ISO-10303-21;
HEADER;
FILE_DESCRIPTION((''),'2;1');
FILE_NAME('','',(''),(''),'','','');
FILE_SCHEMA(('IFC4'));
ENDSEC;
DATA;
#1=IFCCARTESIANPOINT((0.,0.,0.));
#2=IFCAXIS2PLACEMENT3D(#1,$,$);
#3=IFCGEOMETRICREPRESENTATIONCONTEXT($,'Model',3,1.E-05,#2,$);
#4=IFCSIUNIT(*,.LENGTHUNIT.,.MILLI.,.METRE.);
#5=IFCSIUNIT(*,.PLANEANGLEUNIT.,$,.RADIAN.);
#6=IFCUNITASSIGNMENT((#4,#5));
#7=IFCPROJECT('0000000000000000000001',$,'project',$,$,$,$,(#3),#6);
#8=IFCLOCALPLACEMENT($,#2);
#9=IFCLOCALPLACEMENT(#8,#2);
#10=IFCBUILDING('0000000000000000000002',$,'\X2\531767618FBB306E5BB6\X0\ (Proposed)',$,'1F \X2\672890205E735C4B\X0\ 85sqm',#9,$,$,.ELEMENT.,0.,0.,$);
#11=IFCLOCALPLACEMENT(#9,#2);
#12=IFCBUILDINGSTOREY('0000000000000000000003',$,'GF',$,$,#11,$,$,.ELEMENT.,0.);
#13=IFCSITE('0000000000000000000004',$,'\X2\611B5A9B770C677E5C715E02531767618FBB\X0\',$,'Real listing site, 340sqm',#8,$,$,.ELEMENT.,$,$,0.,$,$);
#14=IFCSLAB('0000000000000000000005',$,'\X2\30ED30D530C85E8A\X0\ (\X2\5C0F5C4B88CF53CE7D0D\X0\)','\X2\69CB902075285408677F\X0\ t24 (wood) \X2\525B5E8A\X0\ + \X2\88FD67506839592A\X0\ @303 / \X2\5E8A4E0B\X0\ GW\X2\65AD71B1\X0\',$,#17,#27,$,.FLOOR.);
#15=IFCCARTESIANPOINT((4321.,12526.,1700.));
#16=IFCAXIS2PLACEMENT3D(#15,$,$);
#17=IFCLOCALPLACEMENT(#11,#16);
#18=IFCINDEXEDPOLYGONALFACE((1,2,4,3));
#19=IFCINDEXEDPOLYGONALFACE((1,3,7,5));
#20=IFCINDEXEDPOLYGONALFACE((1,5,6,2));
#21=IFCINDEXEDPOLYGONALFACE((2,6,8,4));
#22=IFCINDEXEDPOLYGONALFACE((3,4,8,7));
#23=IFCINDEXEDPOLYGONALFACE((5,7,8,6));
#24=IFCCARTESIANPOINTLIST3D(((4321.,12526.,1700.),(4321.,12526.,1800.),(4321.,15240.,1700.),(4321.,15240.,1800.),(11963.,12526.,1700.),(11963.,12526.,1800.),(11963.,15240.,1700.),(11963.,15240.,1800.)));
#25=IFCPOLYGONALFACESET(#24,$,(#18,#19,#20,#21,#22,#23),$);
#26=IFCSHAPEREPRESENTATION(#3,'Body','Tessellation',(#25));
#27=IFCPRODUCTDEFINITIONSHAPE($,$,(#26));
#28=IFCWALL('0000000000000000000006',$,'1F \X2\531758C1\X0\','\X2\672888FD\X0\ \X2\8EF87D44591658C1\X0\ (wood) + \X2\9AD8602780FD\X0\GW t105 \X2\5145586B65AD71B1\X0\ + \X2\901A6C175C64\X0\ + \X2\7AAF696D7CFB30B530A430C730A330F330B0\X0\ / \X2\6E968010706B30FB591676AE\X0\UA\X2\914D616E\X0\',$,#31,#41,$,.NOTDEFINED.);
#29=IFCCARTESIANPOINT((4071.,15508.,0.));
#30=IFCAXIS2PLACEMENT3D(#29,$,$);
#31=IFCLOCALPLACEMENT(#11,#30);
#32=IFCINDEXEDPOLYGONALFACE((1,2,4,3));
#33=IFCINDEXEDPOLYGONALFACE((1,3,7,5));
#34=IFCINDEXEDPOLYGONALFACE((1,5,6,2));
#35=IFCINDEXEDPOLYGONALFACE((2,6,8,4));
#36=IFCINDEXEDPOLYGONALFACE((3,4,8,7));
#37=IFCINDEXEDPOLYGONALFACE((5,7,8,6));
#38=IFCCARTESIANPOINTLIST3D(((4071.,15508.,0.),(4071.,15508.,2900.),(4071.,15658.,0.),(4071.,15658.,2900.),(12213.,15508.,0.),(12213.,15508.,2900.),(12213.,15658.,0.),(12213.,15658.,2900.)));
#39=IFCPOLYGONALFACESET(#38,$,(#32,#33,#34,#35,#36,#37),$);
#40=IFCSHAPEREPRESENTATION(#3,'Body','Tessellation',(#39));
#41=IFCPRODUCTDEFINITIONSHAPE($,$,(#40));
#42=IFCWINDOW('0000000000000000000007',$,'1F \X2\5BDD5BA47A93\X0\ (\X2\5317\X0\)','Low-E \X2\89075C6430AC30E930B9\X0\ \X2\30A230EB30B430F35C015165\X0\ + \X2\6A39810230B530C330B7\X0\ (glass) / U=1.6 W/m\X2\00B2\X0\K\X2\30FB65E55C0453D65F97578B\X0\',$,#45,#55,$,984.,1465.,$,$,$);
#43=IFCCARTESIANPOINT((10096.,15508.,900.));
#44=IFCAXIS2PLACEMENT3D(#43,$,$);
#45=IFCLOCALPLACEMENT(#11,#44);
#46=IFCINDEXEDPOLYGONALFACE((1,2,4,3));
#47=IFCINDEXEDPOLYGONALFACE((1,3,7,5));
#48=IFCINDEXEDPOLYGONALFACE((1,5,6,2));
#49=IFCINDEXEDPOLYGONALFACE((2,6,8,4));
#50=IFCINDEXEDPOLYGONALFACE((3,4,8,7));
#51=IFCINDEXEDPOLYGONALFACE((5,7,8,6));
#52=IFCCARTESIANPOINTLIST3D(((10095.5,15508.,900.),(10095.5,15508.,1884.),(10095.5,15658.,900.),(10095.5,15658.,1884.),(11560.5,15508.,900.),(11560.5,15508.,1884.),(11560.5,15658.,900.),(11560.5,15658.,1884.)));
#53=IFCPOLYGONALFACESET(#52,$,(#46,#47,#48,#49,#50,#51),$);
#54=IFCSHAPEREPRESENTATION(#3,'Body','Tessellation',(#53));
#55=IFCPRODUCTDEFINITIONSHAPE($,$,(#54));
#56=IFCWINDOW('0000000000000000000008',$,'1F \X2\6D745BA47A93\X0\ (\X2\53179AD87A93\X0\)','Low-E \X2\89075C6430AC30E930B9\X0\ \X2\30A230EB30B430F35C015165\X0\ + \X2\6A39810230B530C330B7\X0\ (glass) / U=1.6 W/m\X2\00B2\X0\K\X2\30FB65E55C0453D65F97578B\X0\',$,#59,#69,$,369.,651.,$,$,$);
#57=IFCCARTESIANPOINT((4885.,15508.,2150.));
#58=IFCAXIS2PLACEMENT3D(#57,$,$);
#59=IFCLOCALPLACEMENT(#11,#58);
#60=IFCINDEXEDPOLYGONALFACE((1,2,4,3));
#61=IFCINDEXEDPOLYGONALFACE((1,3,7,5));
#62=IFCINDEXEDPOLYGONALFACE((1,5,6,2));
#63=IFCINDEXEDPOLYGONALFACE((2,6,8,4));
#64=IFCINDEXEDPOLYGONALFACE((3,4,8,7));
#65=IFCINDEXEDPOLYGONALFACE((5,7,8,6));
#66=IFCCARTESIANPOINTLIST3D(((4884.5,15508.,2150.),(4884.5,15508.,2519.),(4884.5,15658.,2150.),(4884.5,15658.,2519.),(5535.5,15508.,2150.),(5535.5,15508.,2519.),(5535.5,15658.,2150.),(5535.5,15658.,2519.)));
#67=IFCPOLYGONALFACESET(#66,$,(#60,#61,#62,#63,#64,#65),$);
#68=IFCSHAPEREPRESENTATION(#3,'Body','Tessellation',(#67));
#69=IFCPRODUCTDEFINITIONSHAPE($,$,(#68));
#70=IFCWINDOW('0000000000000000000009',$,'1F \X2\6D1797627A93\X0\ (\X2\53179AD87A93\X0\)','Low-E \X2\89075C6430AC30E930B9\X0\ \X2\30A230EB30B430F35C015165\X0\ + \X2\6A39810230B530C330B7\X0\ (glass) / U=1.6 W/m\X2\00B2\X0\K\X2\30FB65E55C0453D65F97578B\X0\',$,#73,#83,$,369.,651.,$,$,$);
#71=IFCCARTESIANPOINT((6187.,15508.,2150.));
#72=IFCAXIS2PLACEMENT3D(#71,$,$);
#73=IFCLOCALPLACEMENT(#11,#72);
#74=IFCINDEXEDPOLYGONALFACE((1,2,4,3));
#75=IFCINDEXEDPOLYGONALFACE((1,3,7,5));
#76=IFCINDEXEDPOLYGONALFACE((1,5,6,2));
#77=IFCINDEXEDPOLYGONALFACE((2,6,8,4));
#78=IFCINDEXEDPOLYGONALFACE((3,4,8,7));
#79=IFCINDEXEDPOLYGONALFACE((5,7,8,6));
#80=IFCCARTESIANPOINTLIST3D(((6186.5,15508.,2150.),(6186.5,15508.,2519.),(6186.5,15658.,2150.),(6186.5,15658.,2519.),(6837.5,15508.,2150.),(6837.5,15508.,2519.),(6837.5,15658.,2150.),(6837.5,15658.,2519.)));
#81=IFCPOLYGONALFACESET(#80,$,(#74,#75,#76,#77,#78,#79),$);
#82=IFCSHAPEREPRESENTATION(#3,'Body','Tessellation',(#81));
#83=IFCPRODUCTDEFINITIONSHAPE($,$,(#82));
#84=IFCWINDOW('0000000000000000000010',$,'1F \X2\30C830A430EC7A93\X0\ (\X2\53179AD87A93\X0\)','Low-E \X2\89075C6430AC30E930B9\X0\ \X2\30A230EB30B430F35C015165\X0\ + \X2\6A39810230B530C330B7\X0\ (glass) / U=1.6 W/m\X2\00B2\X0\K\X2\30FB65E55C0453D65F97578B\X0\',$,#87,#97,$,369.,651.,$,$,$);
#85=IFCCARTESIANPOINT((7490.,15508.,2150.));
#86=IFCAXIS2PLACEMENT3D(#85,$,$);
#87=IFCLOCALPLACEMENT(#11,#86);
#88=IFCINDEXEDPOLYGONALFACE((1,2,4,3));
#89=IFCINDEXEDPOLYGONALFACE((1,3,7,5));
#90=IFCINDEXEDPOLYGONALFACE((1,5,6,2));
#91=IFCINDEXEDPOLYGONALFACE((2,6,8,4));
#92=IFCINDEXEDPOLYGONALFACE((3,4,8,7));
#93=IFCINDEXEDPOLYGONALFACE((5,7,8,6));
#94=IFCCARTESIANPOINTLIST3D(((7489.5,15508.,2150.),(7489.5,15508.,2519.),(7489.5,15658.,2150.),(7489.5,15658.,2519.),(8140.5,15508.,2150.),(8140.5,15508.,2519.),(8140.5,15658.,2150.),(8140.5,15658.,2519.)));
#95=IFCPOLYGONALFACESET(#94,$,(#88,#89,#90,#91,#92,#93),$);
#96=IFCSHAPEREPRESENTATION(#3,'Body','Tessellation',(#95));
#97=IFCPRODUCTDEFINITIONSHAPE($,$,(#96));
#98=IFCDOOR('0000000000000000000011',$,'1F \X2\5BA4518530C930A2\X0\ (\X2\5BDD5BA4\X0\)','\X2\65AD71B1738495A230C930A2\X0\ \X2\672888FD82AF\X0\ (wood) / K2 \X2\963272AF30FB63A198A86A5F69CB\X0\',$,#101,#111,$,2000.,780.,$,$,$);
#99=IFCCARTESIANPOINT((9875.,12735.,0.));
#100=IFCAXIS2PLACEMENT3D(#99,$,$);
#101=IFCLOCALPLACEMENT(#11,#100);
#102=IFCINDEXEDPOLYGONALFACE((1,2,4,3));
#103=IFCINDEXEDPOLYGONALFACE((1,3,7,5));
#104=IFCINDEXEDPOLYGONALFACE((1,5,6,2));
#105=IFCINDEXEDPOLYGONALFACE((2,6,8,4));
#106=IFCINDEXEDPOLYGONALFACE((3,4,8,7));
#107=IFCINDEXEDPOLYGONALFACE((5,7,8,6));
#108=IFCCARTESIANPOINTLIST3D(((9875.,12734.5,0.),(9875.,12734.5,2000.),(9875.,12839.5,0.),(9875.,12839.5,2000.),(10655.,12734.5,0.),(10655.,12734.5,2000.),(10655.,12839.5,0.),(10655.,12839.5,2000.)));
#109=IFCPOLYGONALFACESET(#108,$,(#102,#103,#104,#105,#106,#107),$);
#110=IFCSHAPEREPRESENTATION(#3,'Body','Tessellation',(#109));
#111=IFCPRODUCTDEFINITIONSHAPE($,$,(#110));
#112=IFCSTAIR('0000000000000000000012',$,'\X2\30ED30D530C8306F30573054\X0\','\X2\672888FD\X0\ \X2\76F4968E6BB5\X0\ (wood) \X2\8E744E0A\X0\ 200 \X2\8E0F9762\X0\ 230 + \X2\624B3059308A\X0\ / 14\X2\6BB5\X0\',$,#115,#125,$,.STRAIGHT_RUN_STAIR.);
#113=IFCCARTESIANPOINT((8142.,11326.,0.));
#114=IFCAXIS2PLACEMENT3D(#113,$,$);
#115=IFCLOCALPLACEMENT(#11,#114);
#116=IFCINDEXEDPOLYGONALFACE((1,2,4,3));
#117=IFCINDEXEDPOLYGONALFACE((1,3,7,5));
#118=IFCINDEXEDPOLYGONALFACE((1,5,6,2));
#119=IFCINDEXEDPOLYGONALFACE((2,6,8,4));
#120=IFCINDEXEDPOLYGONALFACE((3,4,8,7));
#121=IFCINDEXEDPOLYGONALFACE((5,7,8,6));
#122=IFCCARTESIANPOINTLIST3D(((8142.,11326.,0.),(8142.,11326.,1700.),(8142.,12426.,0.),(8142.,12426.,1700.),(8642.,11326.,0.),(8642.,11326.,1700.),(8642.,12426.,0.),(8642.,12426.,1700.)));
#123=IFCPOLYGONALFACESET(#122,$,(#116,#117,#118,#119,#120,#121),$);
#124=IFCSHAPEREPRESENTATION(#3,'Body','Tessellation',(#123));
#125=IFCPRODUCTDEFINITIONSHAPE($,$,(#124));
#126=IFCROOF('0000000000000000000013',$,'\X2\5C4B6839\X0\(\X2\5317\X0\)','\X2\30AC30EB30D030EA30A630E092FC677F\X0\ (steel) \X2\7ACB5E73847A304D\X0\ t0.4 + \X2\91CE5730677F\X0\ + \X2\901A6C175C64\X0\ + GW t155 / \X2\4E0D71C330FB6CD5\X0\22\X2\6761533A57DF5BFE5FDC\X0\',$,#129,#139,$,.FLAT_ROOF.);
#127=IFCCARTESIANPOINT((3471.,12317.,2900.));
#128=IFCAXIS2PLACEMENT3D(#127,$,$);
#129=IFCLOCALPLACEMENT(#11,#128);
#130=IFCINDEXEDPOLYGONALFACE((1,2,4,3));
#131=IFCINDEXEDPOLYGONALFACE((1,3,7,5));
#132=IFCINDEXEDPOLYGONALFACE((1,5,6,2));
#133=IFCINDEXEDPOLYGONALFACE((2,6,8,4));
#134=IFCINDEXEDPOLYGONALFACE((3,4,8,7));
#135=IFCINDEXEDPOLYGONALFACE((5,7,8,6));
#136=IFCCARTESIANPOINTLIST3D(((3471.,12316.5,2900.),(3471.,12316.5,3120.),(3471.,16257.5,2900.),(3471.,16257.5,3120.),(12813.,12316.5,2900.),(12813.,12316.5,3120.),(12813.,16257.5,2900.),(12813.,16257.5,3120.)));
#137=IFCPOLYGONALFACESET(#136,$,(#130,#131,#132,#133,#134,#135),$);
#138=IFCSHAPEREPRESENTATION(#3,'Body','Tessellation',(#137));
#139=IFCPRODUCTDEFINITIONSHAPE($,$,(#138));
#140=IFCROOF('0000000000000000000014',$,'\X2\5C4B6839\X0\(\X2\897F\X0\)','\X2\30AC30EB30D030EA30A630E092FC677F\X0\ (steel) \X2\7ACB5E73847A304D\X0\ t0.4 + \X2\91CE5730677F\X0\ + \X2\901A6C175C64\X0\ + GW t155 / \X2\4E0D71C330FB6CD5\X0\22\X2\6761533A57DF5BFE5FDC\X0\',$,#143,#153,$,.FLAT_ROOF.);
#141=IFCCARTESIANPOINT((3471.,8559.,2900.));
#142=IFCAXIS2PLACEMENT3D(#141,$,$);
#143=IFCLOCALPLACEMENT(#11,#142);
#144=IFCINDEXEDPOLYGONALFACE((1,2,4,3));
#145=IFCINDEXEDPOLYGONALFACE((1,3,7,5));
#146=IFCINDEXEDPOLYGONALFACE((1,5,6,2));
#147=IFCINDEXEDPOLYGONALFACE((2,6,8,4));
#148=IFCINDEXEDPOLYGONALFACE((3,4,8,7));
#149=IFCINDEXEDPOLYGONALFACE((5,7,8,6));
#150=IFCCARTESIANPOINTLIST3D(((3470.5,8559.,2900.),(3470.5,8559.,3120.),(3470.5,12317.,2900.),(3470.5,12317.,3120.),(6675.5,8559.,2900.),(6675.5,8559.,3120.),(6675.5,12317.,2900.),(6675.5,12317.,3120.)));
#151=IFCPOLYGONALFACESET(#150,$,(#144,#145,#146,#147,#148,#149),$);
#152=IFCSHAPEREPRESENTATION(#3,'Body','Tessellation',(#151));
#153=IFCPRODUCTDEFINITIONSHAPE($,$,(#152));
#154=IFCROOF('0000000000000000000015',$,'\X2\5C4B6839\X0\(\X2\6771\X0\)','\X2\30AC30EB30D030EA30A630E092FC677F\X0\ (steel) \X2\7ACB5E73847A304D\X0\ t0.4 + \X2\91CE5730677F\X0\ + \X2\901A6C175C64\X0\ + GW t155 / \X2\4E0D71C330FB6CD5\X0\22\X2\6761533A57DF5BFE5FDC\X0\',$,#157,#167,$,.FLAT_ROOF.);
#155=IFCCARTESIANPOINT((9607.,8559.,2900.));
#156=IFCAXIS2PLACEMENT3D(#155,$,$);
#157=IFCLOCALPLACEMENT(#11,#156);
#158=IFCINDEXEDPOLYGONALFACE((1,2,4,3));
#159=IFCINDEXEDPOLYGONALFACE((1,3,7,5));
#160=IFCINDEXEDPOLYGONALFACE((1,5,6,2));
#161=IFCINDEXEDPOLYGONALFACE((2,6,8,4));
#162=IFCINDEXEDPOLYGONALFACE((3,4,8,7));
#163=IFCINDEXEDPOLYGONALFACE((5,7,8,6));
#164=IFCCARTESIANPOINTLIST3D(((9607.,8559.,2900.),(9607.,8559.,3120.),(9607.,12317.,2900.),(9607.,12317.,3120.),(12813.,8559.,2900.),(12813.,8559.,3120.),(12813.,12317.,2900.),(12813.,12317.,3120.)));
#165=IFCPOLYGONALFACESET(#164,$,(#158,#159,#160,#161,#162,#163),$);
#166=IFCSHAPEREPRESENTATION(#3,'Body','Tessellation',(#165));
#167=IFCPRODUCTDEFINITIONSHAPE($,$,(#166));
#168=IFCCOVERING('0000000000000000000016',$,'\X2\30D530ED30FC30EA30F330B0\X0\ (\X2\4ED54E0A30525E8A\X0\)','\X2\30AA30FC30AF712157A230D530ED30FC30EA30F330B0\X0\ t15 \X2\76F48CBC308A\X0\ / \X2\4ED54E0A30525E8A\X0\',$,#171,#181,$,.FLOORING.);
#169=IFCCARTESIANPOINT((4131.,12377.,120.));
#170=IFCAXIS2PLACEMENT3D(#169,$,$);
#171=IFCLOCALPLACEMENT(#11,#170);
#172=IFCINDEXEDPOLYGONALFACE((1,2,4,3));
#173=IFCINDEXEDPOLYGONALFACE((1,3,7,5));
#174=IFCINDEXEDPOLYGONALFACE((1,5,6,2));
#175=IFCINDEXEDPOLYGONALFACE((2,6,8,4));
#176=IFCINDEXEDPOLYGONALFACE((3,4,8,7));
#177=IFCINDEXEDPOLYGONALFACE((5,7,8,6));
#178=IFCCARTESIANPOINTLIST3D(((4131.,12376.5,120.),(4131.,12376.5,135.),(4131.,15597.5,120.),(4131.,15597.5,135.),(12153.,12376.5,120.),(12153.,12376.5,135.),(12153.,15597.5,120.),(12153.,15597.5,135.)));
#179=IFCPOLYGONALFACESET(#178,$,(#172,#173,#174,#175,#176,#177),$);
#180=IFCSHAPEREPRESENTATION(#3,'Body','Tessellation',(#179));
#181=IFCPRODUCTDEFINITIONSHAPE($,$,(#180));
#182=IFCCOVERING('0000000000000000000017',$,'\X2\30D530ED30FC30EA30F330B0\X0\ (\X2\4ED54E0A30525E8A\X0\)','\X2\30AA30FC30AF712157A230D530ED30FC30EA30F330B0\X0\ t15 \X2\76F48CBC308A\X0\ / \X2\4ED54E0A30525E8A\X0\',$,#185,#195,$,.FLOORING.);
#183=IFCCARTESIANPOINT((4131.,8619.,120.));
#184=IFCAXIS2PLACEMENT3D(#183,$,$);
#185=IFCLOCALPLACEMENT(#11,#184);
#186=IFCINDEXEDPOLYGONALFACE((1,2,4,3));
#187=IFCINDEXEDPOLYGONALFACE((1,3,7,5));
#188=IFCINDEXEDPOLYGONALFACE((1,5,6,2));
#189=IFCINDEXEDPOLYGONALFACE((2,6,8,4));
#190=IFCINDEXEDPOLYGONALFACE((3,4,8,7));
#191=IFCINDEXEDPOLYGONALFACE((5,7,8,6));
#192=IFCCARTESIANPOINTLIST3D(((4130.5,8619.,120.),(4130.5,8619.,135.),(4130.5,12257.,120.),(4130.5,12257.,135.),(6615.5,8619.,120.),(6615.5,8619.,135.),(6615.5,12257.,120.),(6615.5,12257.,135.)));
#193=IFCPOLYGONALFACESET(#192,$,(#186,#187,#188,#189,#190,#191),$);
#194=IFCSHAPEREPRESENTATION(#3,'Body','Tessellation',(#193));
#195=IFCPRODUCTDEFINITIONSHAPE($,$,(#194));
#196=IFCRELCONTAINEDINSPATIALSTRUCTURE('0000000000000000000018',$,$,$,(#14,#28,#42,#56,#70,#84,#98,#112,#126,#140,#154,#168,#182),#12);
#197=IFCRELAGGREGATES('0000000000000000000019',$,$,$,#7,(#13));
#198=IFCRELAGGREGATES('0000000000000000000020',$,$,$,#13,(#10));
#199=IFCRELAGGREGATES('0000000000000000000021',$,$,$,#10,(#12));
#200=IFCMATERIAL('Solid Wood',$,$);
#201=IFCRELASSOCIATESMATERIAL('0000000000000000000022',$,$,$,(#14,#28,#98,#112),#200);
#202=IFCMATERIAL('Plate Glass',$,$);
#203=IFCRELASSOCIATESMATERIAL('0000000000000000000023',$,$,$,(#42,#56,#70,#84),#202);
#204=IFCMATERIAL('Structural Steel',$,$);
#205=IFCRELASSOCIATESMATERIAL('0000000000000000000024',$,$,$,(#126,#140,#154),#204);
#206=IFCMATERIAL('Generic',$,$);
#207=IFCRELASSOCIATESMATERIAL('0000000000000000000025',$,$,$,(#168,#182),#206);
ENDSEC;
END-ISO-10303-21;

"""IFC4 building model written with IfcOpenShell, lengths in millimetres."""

from ifc_helpers import new_model, si_unit, frame, frame_2d, origin, place, context, project, spatial, rectangle, extrude, material, element, fill, save


model = new_model("IFC4")

# Units and contexts
model_context = context("Model", 3, precision=1e-05, world=origin())
ifc_project = project(units=[si_unit("LENGTHUNIT", "METRE", prefix="MILLI"), si_unit("PLANEANGLEUNIT", "RADIAN")], contexts=[model_context])

# Site, building, storey
site_placement = place(None, origin())
site = spatial("IfcSite", under=ifc_project, at=site_placement, Name="愛媛県松山市北条辻", ObjectType="Real listing site, 340sqm", CompositionType="ELEMENT", RefElevation=0.0)
building_placement = place(site_placement, origin())
building = spatial("IfcBuilding", under=site, at=building_placement, Name="北条辻の家 (Proposed)", ObjectType="1F 木造平屋 85sqm", CompositionType="ELEMENT", ElevationOfRefHeight=0.0, ElevationOfTerrain=0.0)
storey_placement = place(building_placement, origin())
storey = spatial("IfcBuildingStorey", under=building, at=storey_placement, Name="GF", CompositionType="ELEMENT", Elevation=0.0)

# Slab
ifc_material_1 = material(Name="Solid Wood")
slab_1_placement = place(storey_placement, frame((4321.0, 12526.0, 1700.0)))
element("IfcSlab", 1, at=slab_1_placement, inside=storey, material=ifc_material_1, Name="ロフト床 (小屋裏収納)", Description="構造用合板 t24 (wood) 剛床 + 製材根太 @303 / 床下 GW断熱", PredefinedType="FLOOR", context=model_context, shape_type="SweptSolid", body=[
    extrude(rectangle(XDim=7642.0, YDim=2714.0, at=frame_2d((3821.0, 1357.0))), frame((4321.0, 12526.0, 1700.0)), (0.0, 0.0, 1.0), 100.0),
])

# Wall, openings, windows
wall_1_placement = place(storey_placement, frame((4071.0, 15508.0, 0.0)))
wall_1 = element("IfcWall", 2, at=wall_1_placement, inside=storey, material=ifc_material_1, Name="1F 北壁", Description="木製 軸組外壁 (wood) + 高性能GW t105 充填断熱 + 通気層 + 窯業系サイディング / 準耐火・外皮UA配慮", PredefinedType="NOTDEFINED", context=model_context, shape_type="SweptSolid", body=[
    extrude(rectangle(XDim=8142.0, YDim=150.0, at=frame_2d((4071.0, 75.0))), frame((4071.0, 15508.0, 0.0)), (0.0, 0.0, 1.0), 2900.0),
])
opening_1_placement = place(storey_placement, frame((10096.0, 15508.0, 900.0)))
opening_1 = element("IfcOpeningElement", 3, at=opening_1_placement, cuts=wall_1, PredefinedType="NOTDEFINED", context=model_context, shape_type="SweptSolid", body=[
    extrude(rectangle(XDim=1465.0, YDim=150.0, at=frame_2d((732.0, 75.0))), frame((10096.0, 15508.0, 900.0)), (0.0, 0.0, 1.0), 984.0),
])
opening_2_placement = place(storey_placement, frame((4885.0, 15508.0, 2150.0)))
opening_2 = element("IfcOpeningElement", 4, at=opening_2_placement, cuts=wall_1, PredefinedType="NOTDEFINED", context=model_context, shape_type="SweptSolid", body=[
    extrude(rectangle(XDim=651.0, YDim=150.0, at=frame_2d((325.0, 75.0))), frame((4885.0, 15508.0, 2150.0)), (0.0, 0.0, 1.0), 369.0),
])
opening_3_placement = place(storey_placement, frame((6187.0, 15508.0, 2150.0)))
opening_3 = element("IfcOpeningElement", 5, at=opening_3_placement, cuts=wall_1, PredefinedType="NOTDEFINED", context=model_context, shape_type="SweptSolid", body=[
    extrude(rectangle(XDim=651.0, YDim=150.0, at=frame_2d((325.0, 75.0))), frame((6187.0, 15508.0, 2150.0)), (0.0, 0.0, 1.0), 369.0),
])
opening_4_placement = place(storey_placement, frame((7490.0, 15508.0, 2150.0)))
opening_4 = element("IfcOpeningElement", 6, at=opening_4_placement, cuts=wall_1, PredefinedType="NOTDEFINED", context=model_context, shape_type="SweptSolid", body=[
    extrude(rectangle(XDim=651.0, YDim=150.0, at=frame_2d((325.0, 75.0))), frame((7490.0, 15508.0, 2150.0)), (0.0, 0.0, 1.0), 369.0),
])
ifc_material_2 = material(Name="Plate Glass")
window_1_placement = place(storey_placement, frame((10096.0, 15508.0, 900.0)))
window_1 = element("IfcWindow", 7, at=window_1_placement, inside=storey, material=ifc_material_2, Name="1F 寝室窓 (北)", Description="Low-E 複層ガラス アルゴン封入 + 樹脂サッシ (glass) / U=1.6 W/m²K・日射取得型", OverallHeight=984.0, OverallWidth=1465.0, context=model_context, shape_type="SweptSolid", body=[
    extrude(rectangle(XDim=1465.0, YDim=150.0, at=frame_2d((732.0, 75.0))), frame((10096.0, 15508.0, 900.0)), (0.0, 0.0, 1.0), 984.0),
])
fill(opening_1, window_1)
window_2_placement = place(storey_placement, frame((4885.0, 15508.0, 2150.0)))
window_2 = element("IfcWindow", 8, at=window_2_placement, inside=storey, material=ifc_material_2, Name="1F 浴室窓 (北高窓)", Description="Low-E 複層ガラス アルゴン封入 + 樹脂サッシ (glass) / U=1.6 W/m²K・日射取得型", OverallHeight=369.0, OverallWidth=651.0, context=model_context, shape_type="SweptSolid", body=[
    extrude(rectangle(XDim=651.0, YDim=150.0, at=frame_2d((325.0, 75.0))), frame((4885.0, 15508.0, 2150.0)), (0.0, 0.0, 1.0), 369.0),
])
fill(opening_2, window_2)
window_3_placement = place(storey_placement, frame((6187.0, 15508.0, 2150.0)))
window_3 = element("IfcWindow", 9, at=window_3_placement, inside=storey, material=ifc_material_2, Name="1F 洗面窓 (北高窓)", Description="Low-E 複層ガラス アルゴン封入 + 樹脂サッシ (glass) / U=1.6 W/m²K・日射取得型", OverallHeight=369.0, OverallWidth=651.0, context=model_context, shape_type="SweptSolid", body=[
    extrude(rectangle(XDim=651.0, YDim=150.0, at=frame_2d((325.0, 75.0))), frame((6187.0, 15508.0, 2150.0)), (0.0, 0.0, 1.0), 369.0),
])
fill(opening_3, window_3)
window_4_placement = place(storey_placement, frame((7490.0, 15508.0, 2150.0)))
window_4 = element("IfcWindow", 10, at=window_4_placement, inside=storey, material=ifc_material_2, Name="1F トイレ窓 (北高窓)", Description="Low-E 複層ガラス アルゴン封入 + 樹脂サッシ (glass) / U=1.6 W/m²K・日射取得型", OverallHeight=369.0, OverallWidth=651.0, context=model_context, shape_type="SweptSolid", body=[
    extrude(rectangle(XDim=651.0, YDim=150.0, at=frame_2d((325.0, 75.0))), frame((7490.0, 15508.0, 2150.0)), (0.0, 0.0, 1.0), 369.0),
])
fill(opening_4, window_4)

# Door
door_1_placement = place(storey_placement, frame((9875.0, 12735.0, 0.0)))
element("IfcDoor", 11, at=door_1_placement, inside=storey, material=ifc_material_1, Name="1F 室内ドア (寝室)", Description="断熱玄関ドア 木製芯 (wood) / K2 防犯・採風機構", OverallHeight=2000.0, OverallWidth=780.0, context=model_context, shape_type="SweptSolid", body=[
    extrude(rectangle(XDim=780.0, YDim=105.0, at=frame_2d((390.0, 52.0))), frame((9875.0, 12735.0, 0.0)), (0.0, 0.0, 1.0), 2000.0),
])

# Stair
stair_placement = place(storey_placement, frame((8142.0, 11326.0, 0.0)))
element("IfcStair", 12, at=stair_placement, inside=storey, material=ifc_material_1, Name="ロフトはしご", Description="木製 直階段 (wood) 蹴上 200 踏面 230 + 手すり / 14段", PredefinedType="STRAIGHT_RUN_STAIR", context=model_context, shape_type="SweptSolid", body=[
    extrude(rectangle(XDim=500.0, YDim=1100.0, at=frame_2d((250.0, 550.0))), frame((8142.0, 11326.0, 0.0)), (0.0, 0.0, 1.0), 1700.0),
])

# Roofs
ifc_material_3 = material(Name="Structural Steel")
roof_1_placement = place(storey_placement, frame((3471.0, 12317.0, 2900.0)))
element("IfcRoof", 13, at=roof_1_placement, inside=storey, material=ifc_material_3, Name="屋根(北)", Description="ガルバリウム鋼板 (steel) 立平葺き t0.4 + 野地板 + 通気層 + GW t155 / 不燃・法22条区域対応", PredefinedType="FLAT_ROOF", context=model_context, shape_type="SweptSolid", body=[
    extrude(rectangle(XDim=9342.0, YDim=3941.0, at=frame_2d((4671.0, 1970.0))), frame((3471.0, 12317.0, 2900.0)), (0.0, 0.0, 1.0), 220.0),
])
roof_2_placement = place(storey_placement, frame((3471.0, 8559.0, 2900.0)))
element("IfcRoof", 14, at=roof_2_placement, inside=storey, material=ifc_material_3, Name="屋根(西)", Description="ガルバリウム鋼板 (steel) 立平葺き t0.4 + 野地板 + 通気層 + GW t155 / 不燃・法22条区域対応", PredefinedType="FLAT_ROOF", context=model_context, shape_type="SweptSolid", body=[
    extrude(rectangle(XDim=3205.0, YDim=3758.0, at=frame_2d((1602.0, 1879.0))), frame((3471.0, 8559.0, 2900.0)), (0.0, 0.0, 1.0), 220.0),
])
roof_3_placement = place(storey_placement, frame((9607.0, 8559.0, 2900.0)))
element("IfcRoof", 15, at=roof_3_placement, inside=storey, material=ifc_material_3, Name="屋根(東)", Description="ガルバリウム鋼板 (steel) 立平葺き t0.4 + 野地板 + 通気層 + GW t155 / 不燃・法22条区域対応", PredefinedType="FLAT_ROOF", context=model_context, shape_type="SweptSolid", body=[
    extrude(rectangle(XDim=3206.0, YDim=3758.0, at=frame_2d((1603.0, 1879.0))), frame((9607.0, 8559.0, 2900.0)), (0.0, 0.0, 1.0), 220.0),
])

# Coverings
ifc_material_4 = material(Name="Generic")
covering_1_placement = place(storey_placement, frame((4131.0, 12377.0, 120.0)))
element("IfcCovering", 16, at=covering_1_placement, inside=storey, material=ifc_material_4, Name="フローリング (仕上げ床)", Description="オーク無垢フローリング t15 直貼り / 仕上げ床", PredefinedType="FLOORING", context=model_context, shape_type="SweptSolid", body=[
    extrude(rectangle(XDim=8022.0, YDim=3221.0, at=frame_2d((4011.0, 1610.0))), frame((4131.0, 12377.0, 120.0)), (0.0, 0.0, 1.0), 15.0),
])
covering_2_placement = place(storey_placement, frame((4131.0, 8619.0, 120.0)))
element("IfcCovering", 17, at=covering_2_placement, inside=storey, material=ifc_material_4, Name="フローリング (仕上げ床)", Description="オーク無垢フローリング t15 直貼り / 仕上げ床", PredefinedType="FLOORING", context=model_context, shape_type="SweptSolid", body=[
    extrude(rectangle(XDim=2485.0, YDim=3638.0, at=frame_2d((1242.0, 1819.0))), frame((4131.0, 8619.0, 120.0)), (0.0, 0.0, 1.0), 15.0),
])

save(model, "model.ifc")
